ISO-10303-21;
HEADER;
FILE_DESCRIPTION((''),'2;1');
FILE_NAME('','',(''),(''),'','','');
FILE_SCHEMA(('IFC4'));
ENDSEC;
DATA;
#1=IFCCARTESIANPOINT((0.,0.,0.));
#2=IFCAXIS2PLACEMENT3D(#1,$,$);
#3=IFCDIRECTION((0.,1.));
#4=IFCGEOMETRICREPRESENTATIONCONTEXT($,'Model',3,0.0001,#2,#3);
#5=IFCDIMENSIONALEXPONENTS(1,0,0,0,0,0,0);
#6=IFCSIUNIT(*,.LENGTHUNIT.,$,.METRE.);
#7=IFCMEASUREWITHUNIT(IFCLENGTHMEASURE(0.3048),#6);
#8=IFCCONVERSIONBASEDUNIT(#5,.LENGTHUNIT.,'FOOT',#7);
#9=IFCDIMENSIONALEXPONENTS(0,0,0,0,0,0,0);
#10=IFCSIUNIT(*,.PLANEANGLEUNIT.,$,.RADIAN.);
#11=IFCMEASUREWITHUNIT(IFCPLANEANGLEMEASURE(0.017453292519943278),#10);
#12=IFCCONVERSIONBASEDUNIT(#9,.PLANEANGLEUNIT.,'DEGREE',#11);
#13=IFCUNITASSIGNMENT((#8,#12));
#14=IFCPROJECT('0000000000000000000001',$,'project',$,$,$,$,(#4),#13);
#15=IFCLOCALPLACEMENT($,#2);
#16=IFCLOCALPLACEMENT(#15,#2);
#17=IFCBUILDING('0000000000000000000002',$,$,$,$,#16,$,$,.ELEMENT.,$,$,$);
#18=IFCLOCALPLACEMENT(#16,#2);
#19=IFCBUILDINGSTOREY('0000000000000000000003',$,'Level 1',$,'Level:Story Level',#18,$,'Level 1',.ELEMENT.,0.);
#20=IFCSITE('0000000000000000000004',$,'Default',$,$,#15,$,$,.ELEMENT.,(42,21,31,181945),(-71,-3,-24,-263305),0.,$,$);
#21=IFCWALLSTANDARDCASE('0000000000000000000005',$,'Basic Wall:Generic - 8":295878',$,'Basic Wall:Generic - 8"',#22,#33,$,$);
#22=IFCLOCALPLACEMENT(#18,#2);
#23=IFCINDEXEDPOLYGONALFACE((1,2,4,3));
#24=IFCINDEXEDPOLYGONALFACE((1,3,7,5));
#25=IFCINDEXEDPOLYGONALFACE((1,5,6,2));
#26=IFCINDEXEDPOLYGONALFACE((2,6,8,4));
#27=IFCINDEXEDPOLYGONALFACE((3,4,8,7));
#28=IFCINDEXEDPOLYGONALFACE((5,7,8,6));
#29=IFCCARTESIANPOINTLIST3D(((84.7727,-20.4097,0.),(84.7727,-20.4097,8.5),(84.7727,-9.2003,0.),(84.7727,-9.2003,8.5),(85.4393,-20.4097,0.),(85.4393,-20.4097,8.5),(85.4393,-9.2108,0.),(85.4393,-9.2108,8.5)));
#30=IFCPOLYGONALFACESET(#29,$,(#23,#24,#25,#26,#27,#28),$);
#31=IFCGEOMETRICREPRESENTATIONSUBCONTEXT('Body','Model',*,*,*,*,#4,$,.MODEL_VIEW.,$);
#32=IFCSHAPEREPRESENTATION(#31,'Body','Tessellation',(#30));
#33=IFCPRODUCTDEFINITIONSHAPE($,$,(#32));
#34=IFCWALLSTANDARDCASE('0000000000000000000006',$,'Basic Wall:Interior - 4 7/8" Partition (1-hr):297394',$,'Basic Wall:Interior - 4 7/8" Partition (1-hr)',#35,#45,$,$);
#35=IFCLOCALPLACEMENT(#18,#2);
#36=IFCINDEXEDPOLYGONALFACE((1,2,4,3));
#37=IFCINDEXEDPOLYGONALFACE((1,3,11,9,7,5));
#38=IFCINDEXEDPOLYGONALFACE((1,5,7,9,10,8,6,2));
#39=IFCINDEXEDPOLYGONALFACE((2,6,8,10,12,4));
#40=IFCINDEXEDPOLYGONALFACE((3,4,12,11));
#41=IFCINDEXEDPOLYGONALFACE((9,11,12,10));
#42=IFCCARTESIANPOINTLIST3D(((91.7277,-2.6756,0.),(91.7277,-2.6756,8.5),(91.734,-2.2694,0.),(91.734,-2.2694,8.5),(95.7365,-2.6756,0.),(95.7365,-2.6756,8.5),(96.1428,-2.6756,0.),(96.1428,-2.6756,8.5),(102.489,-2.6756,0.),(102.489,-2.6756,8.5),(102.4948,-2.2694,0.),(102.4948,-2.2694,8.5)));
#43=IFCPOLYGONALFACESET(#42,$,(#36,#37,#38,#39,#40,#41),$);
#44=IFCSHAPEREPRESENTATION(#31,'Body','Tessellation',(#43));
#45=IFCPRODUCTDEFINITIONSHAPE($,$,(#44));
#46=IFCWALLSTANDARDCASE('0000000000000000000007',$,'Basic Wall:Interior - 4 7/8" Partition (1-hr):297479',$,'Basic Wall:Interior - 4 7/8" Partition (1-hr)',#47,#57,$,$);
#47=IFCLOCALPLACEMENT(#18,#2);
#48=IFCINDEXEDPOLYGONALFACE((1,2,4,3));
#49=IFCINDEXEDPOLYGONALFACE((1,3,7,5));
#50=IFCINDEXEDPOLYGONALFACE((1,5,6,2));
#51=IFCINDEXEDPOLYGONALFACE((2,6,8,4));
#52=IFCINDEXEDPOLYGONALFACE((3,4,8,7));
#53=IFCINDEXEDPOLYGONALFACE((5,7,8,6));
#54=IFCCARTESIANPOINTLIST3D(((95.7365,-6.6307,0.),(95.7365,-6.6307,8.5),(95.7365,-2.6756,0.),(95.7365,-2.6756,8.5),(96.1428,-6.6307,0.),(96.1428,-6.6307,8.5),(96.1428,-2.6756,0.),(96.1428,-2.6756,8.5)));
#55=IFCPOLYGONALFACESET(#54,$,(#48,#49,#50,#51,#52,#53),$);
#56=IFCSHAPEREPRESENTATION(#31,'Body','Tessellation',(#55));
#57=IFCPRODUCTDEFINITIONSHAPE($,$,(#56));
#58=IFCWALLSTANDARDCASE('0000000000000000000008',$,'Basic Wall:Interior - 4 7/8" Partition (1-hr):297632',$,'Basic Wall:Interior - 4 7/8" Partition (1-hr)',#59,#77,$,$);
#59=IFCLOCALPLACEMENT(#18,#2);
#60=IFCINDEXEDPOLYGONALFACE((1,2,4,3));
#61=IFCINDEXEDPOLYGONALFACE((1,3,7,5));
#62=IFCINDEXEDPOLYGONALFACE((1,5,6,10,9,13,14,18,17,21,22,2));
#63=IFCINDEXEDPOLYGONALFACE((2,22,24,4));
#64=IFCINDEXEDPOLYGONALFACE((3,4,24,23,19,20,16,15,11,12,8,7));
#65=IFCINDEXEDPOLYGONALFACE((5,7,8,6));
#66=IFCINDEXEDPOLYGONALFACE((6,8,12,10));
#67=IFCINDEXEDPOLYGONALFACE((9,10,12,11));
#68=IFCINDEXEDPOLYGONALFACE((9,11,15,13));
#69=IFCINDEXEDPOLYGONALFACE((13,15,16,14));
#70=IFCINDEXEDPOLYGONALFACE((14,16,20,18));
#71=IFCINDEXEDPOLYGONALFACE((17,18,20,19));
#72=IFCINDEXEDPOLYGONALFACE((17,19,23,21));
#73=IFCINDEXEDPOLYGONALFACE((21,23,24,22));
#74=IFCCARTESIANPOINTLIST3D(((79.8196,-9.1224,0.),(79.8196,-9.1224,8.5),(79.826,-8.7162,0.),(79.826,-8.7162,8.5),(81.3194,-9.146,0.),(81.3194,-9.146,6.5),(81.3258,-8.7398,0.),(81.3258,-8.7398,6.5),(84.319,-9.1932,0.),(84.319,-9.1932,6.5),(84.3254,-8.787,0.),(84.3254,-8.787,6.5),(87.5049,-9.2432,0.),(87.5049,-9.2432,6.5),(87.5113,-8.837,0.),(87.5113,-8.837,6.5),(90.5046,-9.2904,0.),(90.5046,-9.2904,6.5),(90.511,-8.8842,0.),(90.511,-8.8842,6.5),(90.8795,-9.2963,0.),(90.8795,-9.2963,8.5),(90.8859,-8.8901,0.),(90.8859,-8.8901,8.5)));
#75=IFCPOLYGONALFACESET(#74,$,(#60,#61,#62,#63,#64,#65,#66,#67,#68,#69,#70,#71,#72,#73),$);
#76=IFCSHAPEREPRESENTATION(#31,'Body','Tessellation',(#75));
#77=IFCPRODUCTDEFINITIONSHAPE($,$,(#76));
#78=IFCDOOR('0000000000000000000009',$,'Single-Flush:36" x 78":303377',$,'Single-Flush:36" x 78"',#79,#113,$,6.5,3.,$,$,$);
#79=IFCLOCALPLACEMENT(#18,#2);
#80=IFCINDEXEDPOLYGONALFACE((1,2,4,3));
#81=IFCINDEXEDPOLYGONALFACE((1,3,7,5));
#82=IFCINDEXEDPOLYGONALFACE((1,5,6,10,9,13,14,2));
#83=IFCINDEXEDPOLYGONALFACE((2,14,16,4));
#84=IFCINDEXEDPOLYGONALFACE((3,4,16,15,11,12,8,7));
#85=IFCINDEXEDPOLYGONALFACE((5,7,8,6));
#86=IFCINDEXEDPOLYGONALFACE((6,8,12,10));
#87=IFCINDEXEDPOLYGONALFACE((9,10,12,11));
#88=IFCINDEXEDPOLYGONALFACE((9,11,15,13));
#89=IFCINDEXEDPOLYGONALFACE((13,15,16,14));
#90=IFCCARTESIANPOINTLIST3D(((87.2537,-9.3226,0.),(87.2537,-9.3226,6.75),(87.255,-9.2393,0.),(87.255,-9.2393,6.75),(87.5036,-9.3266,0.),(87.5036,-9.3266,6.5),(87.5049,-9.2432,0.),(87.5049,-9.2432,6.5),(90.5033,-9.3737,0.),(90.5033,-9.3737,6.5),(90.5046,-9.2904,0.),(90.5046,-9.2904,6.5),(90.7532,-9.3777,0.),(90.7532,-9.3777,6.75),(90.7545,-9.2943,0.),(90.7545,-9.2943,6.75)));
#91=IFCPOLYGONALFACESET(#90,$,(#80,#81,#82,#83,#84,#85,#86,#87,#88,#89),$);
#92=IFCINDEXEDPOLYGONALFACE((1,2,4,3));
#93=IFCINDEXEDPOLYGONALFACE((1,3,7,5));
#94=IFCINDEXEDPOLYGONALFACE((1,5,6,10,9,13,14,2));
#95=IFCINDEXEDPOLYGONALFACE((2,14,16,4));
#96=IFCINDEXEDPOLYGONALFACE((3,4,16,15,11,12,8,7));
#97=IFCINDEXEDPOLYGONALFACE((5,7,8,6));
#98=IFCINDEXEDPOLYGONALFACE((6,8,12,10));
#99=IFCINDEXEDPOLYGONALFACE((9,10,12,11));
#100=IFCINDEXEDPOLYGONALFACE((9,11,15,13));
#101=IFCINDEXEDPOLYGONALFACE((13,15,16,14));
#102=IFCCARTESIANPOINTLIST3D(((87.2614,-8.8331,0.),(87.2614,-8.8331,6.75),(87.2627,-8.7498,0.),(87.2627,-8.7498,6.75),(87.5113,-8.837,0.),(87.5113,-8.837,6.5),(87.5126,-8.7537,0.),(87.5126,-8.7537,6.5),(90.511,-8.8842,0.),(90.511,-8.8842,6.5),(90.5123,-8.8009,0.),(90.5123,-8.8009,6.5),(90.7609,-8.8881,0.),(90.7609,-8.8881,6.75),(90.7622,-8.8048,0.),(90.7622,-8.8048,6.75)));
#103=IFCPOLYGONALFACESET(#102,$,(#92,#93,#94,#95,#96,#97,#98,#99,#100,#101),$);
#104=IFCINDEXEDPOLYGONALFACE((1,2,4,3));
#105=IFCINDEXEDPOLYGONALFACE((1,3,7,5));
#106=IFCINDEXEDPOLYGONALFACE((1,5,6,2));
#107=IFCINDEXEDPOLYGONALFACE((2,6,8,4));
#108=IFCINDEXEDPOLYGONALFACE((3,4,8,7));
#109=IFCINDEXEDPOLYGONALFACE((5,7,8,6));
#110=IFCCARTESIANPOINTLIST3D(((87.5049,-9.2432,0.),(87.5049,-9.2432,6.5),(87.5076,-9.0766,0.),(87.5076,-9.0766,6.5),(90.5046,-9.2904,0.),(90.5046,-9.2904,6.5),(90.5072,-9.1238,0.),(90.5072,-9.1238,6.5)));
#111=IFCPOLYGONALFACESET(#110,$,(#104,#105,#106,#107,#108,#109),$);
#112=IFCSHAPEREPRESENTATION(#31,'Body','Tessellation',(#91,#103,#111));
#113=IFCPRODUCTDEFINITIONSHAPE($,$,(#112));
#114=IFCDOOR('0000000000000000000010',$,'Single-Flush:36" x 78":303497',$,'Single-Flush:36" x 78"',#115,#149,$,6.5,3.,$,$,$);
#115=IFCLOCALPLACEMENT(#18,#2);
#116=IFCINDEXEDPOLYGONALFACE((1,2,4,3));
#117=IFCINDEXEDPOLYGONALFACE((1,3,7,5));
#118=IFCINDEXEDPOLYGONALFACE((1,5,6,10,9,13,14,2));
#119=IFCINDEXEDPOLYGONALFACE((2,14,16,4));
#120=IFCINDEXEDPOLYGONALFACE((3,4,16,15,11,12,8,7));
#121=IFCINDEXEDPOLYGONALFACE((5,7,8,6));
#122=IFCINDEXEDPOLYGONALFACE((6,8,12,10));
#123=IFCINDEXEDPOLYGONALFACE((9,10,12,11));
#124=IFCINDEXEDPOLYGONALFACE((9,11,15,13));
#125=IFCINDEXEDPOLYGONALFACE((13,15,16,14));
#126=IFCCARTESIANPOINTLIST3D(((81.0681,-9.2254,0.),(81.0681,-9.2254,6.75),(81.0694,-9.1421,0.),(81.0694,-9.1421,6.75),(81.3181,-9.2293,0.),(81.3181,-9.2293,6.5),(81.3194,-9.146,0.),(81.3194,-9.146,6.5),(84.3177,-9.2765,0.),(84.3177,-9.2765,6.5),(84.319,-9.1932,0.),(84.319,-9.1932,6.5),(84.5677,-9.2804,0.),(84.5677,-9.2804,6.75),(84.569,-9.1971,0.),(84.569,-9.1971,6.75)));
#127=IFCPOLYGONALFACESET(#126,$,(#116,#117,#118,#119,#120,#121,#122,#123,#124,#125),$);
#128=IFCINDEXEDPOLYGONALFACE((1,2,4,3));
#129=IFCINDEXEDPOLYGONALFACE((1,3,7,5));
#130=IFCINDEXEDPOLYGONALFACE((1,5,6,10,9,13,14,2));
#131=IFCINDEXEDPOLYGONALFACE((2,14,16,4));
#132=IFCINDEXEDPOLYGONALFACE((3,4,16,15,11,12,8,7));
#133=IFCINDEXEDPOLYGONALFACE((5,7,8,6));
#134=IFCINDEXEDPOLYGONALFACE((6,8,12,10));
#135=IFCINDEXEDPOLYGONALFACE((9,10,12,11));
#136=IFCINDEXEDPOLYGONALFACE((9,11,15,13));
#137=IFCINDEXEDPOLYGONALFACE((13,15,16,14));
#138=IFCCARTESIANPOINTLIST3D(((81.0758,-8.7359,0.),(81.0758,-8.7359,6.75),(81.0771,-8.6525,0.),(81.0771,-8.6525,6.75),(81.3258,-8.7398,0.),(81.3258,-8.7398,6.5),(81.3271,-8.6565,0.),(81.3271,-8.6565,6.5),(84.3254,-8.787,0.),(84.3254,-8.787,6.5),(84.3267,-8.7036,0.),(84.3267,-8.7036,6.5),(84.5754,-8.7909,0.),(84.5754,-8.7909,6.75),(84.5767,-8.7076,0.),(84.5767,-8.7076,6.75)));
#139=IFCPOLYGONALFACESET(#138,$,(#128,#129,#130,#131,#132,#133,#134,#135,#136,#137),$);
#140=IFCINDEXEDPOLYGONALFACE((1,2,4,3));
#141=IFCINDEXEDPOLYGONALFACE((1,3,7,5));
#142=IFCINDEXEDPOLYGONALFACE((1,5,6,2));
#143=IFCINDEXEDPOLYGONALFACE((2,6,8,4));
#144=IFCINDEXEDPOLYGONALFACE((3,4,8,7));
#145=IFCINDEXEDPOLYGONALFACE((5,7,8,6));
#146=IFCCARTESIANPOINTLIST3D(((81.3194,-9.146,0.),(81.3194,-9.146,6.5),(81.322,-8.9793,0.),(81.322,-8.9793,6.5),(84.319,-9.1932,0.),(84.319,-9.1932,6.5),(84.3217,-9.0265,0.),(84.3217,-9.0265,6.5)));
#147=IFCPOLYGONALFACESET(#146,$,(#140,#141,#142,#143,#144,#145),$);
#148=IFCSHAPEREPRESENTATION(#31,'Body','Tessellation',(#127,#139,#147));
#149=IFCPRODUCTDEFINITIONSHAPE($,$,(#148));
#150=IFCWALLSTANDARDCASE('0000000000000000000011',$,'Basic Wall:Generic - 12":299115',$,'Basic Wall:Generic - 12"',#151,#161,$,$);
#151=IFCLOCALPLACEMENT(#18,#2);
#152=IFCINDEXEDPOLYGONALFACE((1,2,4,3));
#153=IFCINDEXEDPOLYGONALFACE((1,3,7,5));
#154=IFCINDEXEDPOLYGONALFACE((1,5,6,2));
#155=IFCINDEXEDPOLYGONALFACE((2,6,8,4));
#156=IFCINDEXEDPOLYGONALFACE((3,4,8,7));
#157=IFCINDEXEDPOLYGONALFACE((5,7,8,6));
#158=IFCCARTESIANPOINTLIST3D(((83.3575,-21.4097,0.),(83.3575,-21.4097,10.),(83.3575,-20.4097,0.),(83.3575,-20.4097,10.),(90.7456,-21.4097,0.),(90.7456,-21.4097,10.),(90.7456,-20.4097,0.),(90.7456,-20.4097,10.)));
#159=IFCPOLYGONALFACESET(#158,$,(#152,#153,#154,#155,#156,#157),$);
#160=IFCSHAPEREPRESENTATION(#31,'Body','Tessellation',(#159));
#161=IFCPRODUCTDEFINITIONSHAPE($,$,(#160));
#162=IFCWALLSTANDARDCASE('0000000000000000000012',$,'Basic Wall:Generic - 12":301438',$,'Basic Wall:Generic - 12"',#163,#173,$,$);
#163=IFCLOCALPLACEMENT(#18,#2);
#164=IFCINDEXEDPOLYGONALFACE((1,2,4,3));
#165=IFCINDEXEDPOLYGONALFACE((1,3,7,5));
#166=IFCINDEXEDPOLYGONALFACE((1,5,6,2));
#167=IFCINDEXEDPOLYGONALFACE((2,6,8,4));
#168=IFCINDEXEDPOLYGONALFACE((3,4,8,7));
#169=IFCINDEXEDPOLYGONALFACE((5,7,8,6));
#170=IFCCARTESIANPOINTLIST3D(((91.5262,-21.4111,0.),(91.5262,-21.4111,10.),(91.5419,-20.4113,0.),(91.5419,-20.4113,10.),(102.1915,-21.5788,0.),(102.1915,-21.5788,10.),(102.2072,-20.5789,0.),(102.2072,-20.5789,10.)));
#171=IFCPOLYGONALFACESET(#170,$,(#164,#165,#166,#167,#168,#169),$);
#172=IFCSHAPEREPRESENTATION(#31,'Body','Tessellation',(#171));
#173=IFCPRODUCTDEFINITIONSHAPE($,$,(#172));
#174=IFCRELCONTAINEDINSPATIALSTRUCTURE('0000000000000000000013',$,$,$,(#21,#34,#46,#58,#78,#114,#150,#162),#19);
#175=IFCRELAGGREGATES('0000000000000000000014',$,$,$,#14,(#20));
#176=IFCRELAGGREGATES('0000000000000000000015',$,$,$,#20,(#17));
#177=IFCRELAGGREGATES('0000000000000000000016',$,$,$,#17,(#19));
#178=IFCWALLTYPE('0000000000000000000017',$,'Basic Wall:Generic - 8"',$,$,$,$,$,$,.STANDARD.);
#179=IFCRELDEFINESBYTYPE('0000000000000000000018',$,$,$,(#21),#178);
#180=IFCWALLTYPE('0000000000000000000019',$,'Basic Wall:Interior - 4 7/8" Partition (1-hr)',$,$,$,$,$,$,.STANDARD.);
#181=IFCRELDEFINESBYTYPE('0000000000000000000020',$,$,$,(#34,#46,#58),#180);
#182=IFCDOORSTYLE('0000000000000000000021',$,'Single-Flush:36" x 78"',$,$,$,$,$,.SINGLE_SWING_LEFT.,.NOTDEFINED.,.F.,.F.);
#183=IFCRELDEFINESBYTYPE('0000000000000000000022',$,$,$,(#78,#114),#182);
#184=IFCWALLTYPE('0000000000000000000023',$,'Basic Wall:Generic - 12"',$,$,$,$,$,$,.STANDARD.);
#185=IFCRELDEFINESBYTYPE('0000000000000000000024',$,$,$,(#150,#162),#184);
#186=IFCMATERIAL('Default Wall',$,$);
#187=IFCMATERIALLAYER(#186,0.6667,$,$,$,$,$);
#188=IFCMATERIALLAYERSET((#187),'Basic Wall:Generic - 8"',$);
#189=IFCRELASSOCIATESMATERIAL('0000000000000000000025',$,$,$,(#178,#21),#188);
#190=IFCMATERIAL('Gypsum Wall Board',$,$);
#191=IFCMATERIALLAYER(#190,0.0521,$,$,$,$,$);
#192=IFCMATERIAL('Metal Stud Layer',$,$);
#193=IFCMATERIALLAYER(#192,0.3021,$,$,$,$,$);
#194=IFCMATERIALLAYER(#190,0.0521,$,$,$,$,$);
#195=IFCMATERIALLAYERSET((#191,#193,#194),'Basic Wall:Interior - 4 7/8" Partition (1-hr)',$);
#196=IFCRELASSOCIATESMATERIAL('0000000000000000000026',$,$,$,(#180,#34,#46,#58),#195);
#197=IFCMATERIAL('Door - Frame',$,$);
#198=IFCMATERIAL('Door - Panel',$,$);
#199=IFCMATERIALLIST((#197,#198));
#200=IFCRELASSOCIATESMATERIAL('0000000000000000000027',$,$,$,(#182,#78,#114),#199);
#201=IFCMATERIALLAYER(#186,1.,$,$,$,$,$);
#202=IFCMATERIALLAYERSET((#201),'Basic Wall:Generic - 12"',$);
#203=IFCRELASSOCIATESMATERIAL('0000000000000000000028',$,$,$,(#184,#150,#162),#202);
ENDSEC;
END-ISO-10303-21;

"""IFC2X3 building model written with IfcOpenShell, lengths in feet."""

from ifc_helpers import new_model, entity, si_unit, converted_unit, direction, frame, frame_2d, origin, origin_2d_with_axis, place, context, subcontext, project, spatial, polyline, rectangle, outline, extrude, source, transform, mapped, material, material_list, layer, layer_set, layer_usage, type_object, type_shapes, element, fill, save


model = new_model("IFC2X3")

# Units and contexts
model_context = context("Model", 3, precision=0.0001, world=origin(), true_north=direction((0.0, 1.0)))
body_context = subcontext(model_context, "Body", "Model", "MODEL_VIEW")
ifc_project = project(units=[converted_unit("LENGTHUNIT", "FOOT", entity("IfcLengthMeasure", 0.3048), si_unit("LENGTHUNIT", "METRE"), dimensions=[1, 0, 0, 0, 0, 0, 0]), converted_unit("PLANEANGLEUNIT", "DEGREE", entity("IfcPlaneAngleMeasure", 0.017453292519943278), si_unit("PLANEANGLEUNIT", "RADIAN"), dimensions=[0, 0, 0, 0, 0, 0, 0])], contexts=[model_context])

# Site, building, storey
site_placement = place(None, origin())
site = spatial("IfcSite", under=ifc_project, at=site_placement, Name="Default", CompositionType="ELEMENT", RefLatitude=(42, 21, 31, 181945), RefLongitude=(-71, -3, -24, -263305), RefElevation=0.0)
building_placement = place(site_placement, origin())
building = spatial("IfcBuilding", under=site, at=building_placement, CompositionType="ELEMENT")
storey_placement = place(building_placement, origin())
storey = spatial("IfcBuildingStorey", under=building, at=storey_placement, Name="Level 1", ObjectType="Level:Story Level", LongName="Level 1", CompositionType="ELEMENT", Elevation=0.0)

# Walls
ifc_material_1 = material(Name="Default Wall")
ifc_layer_1 = layer(ifc_material_1, 0.6667)
ifc_layer_set_1 = layer_set([ifc_layer_1], Name="Basic Wall:Generic - 8\"")
ifc_layer_usage_1 = layer_usage(ifc_layer_set_1, "AXIS2", "NEGATIVE", 0.3333)
wall_type_1 = type_object("IfcWallType", Name="Basic Wall:Generic - 8\"", PredefinedType="STANDARD", material=ifc_layer_set_1)
wall_1_placement = place(storey_placement, frame((85.106, -9.2003, 0.0), z_axis=(0.0, 0.0, 1.0), x_axis=(0.0, -1.0, 0.0)))
element("IfcWallStandardCase", 1, at=wall_1_placement, inside=storey, type_object=wall_type_1, material=ifc_layer_usage_1, Name="Basic Wall:Generic - 8\":295878", ObjectType="Basic Wall:Generic - 8\"", context=body_context, shape_type="SweptSolid", body=[
    extrude(outline(polyline([(11.2094, -0.3333), (11.2094, 0.3333), (0.0105, 0.3333), (0.0, -0.3333), (11.2094, -0.3333)])), origin(), (0.0, 0.0, 1.0), 8.5),
])
ifc_material_2 = material(Name="Gypsum Wall Board")
ifc_layer_2 = layer(ifc_material_2, 0.0521)
ifc_material_3 = material(Name="Metal Stud Layer")
ifc_layer_3 = layer(ifc_material_3, 0.3021)
ifc_layer_4 = layer(ifc_material_2, 0.0521)
ifc_layer_set_2 = layer_set([ifc_layer_2, ifc_layer_3, ifc_layer_4], Name="Basic Wall:Interior - 4 7/8\" Partition (1-hr)")
ifc_layer_usage_2 = layer_usage(ifc_layer_set_2, "AXIS2", "NEGATIVE", 0.2031)
wall_type_2 = type_object("IfcWallType", Name="Basic Wall:Interior - 4 7/8\" Partition (1-hr)", PredefinedType="STANDARD", material=ifc_layer_set_2)
wall_2_placement = place(storey_placement, frame((102.4948, -2.4725, 0.0), z_axis=(0.0, 0.0, 1.0), x_axis=(-1.0, 0.0, 0.0)))
element("IfcWallStandardCase", 2, at=wall_2_placement, inside=storey, type_object=wall_type_2, material=ifc_layer_usage_2, Name="Basic Wall:Interior - 4 7/8\" Partition (1-hr):297394", ObjectType="Basic Wall:Interior - 4 7/8\" Partition (1-hr)", context=body_context, shape_type="SweptSolid", body=[
    extrude(outline(polyline([(10.7608, -0.2031), (10.7672, 0.2031), (6.7583, 0.2031), (6.352, 0.2031), (0.0058, 0.2031), (0.0, -0.2031), (10.7608, -0.2031)])), origin(), (0.0, 0.0, 1.0), 8.5),
])
ifc_layer_usage_3 = layer_usage(ifc_layer_set_2, "AXIS2", "NEGATIVE", 0.2031)
wall_3_placement = place(storey_placement, frame((95.9397, -2.6756, 0.0), z_axis=(0.0, 0.0, 1.0), x_axis=(0.0, -1.0, 0.0)))
element("IfcWallStandardCase", 3, at=wall_3_placement, inside=storey, type_object=wall_type_2, material=ifc_layer_usage_3, Name="Basic Wall:Interior - 4 7/8\" Partition (1-hr):297479", ObjectType="Basic Wall:Interior - 4 7/8\" Partition (1-hr)", context=body_context, shape_type="SweptSolid", body=[
    extrude(rectangle(XDim=3.9551, YDim=0.4062, at=frame_2d((1.9776, 0.0), x_axis=(-1.0, 0.0))), origin(), (0.0, 0.0, 1.0), 8.5),
])

# Wall, openings, doors
ifc_layer_usage_4 = layer_usage(ifc_layer_set_2, "AXIS2", "NEGATIVE", 0.2031)
wall_4_placement = place(storey_placement, frame((90.8827, -9.0932, 0.0), z_axis=(0.0, 0.0, 1.0), x_axis=(-0.999876, 0.015721, 0.0)))
wall_4 = element("IfcWallStandardCase", 4, at=wall_4_placement, inside=storey, type_object=wall_type_2, material=ifc_layer_usage_4, Name="Basic Wall:Interior - 4 7/8\" Partition (1-hr):297632", ObjectType="Basic Wall:Interior - 4 7/8\" Partition (1-hr)", context=body_context, shape_type="SweptSolid", body=[
    extrude(rectangle(XDim=11.0613, YDim=0.4063, at=frame_2d((5.5306, 0.0), x_axis=(-1.0, 0.0))), origin(), (0.0, 0.0, 1.0), 8.5),
])
opening_1_placement = place(wall_4_placement, frame((0.375, -0.2031, 0.0)))
opening_1 = element("IfcOpeningElement", 5, at=opening_1_placement, cuts=wall_4, ObjectType="Opening", context=body_context, shape_type="SweptSolid", body=[
    extrude(rectangle(XDim=3.0, YDim=6.5, at=frame_2d((3.25, 1.5), x_axis=(0.0, -1.0))), frame((0.0, 0.0, 0.0), z_axis=(0.0, 1.0, 0.0), x_axis=(0.0, 0.0, 1.0)), (0.0, 0.0, 1.0), 0.4062),
])
opening_2_placement = place(wall_4_placement, frame((6.5613, -0.2031, 0.0)))
opening_2 = element("IfcOpeningElement", 6, at=opening_2_placement, cuts=wall_4, ObjectType="Opening", context=body_context, shape_type="SweptSolid", body=[
    extrude(rectangle(XDim=3.0, YDim=6.5, at=frame_2d((3.25, 1.5), x_axis=(0.0, -1.0))), frame((0.0, 0.0, 0.0), z_axis=(0.0, 1.0, 0.0), x_axis=(0.0, 0.0, 1.0)), (0.0, 0.0, 1.0), 0.4062),
])
ifc_material_4 = material(Name="Door - Frame")
ifc_material_5 = material(Name="Door - Panel")
ifc_material_list = material_list([ifc_material_4, ifc_material_5])
door_style = type_object("IfcDoorStyle", Name="Single-Flush:36\" x 78\"", ConstructionType="NOTDEFINED", OperationType="SINGLE_SWING_LEFT", ParameterTakesPrecedence=False, Sizeable=False, material=ifc_material_list)
shared_shape_1 = source(origin(), body_context, "Body", "SweptSolid", [
    extrude(outline(polyline([(-1.75, -3.4375), (1.75, -3.4375), (1.75, 3.3125), (1.5, 3.3125), (1.5, -3.1875), (-1.5, -3.1875), (-1.5, 3.3125), (-1.75, 3.3125), (-1.75, -3.4375)])), frame((1.5, 0.4896, 3.3125), z_axis=(0.0, -1.0, 0.0), x_axis=(-1.0, 0.0, 0.0)), (0.0, 0.0, 1.0), 0.0833),
    extrude(outline(polyline([(-3.4375, -1.75), (3.3125, -1.75), (3.3125, -1.5), (-3.1875, -1.5), (-3.1875, 1.5), (3.3125, 1.5), (3.3125, 1.75), (-3.4375, 1.75), (-3.4375, -1.75)])), frame((1.5, 0.0, 3.3125), z_axis=(0.0, -1.0, 0.0), x_axis=(0.0, 0.0, -1.0)), (0.0, 0.0, 1.0), 0.0833),
    extrude(rectangle(XDim=3.0, YDim=0.1667, at=origin_2d_with_axis()), frame((1.5, 0.3229, 0.0)), (0.0, 0.0, 1.0), 6.5),
])
type_shapes(door_style, [shared_shape_1])
door_1_placement = place(opening_1_placement, origin())
door_1 = element("IfcDoor", 7, at=door_1_placement, inside=storey, type_object=door_style, material=ifc_material_list, Name="Single-Flush:36\" x 78\":303377", ObjectType="Single-Flush:36\" x 78\"", OverallHeight=6.5, OverallWidth=3.0, context=body_context, shape_type="MappedRepresentation", body=[
    mapped(shared_shape_1, transform((0.0, 0.0, 0.0), scale=1.0)),
])
fill(opening_1, door_1)
door_2_placement = place(opening_2_placement, origin())
door_2 = element("IfcDoor", 8, at=door_2_placement, inside=storey, type_object=door_style, material=ifc_material_list, Name="Single-Flush:36\" x 78\":303497", ObjectType="Single-Flush:36\" x 78\"", OverallHeight=6.5, OverallWidth=3.0, context=body_context, shape_type="MappedRepresentation", body=[
    mapped(shared_shape_1, transform((0.0, 0.0, 0.0), scale=1.0)),
])
fill(opening_2, door_2)

# Walls
ifc_layer_5 = layer(ifc_material_1, 1.0)
ifc_layer_set_3 = layer_set([ifc_layer_5], Name="Basic Wall:Generic - 12\"")
ifc_layer_usage_5 = layer_usage(ifc_layer_set_3, "AXIS2", "NEGATIVE", 0.5)
wall_type_3 = type_object("IfcWallType", Name="Basic Wall:Generic - 12\"", PredefinedType="STANDARD", material=ifc_layer_set_3)
wall_5_placement = place(storey_placement, frame((83.3575, -20.9097, 0.0)))
element("IfcWallStandardCase", 9, at=wall_5_placement, inside=storey, type_object=wall_type_3, material=ifc_layer_usage_5, Name="Basic Wall:Generic - 12\":299115", ObjectType="Basic Wall:Generic - 12\"", context=body_context, shape_type="SweptSolid", body=[
    extrude(rectangle(XDim=7.388, YDim=1.0, at=frame_2d((3.694, 0.0), x_axis=(-1.0, 0.0))), origin(), (0.0, 0.0, 1.0), 10.0),
])
ifc_layer_usage_6 = layer_usage(ifc_layer_set_3, "AXIS2", "NEGATIVE", 0.5)
wall_6_placement = place(storey_placement, frame((91.534, -20.9112, 0.0), z_axis=(0.0, 0.0, 1.0), x_axis=(0.999876, -0.015721, 0.0)))
element("IfcWallStandardCase", 10, at=wall_6_placement, inside=storey, type_object=wall_type_3, material=ifc_layer_usage_6, Name="Basic Wall:Generic - 12\":301438", ObjectType="Basic Wall:Generic - 12\"", context=body_context, shape_type="SweptSolid", body=[
    extrude(rectangle(XDim=10.6667, YDim=1.0, at=frame_2d((5.3333, 0.0), x_axis=(-1.0, 0.0))), origin(), (0.0, 0.0, 1.0), 10.0),
])

save(model, "model.ifc")
